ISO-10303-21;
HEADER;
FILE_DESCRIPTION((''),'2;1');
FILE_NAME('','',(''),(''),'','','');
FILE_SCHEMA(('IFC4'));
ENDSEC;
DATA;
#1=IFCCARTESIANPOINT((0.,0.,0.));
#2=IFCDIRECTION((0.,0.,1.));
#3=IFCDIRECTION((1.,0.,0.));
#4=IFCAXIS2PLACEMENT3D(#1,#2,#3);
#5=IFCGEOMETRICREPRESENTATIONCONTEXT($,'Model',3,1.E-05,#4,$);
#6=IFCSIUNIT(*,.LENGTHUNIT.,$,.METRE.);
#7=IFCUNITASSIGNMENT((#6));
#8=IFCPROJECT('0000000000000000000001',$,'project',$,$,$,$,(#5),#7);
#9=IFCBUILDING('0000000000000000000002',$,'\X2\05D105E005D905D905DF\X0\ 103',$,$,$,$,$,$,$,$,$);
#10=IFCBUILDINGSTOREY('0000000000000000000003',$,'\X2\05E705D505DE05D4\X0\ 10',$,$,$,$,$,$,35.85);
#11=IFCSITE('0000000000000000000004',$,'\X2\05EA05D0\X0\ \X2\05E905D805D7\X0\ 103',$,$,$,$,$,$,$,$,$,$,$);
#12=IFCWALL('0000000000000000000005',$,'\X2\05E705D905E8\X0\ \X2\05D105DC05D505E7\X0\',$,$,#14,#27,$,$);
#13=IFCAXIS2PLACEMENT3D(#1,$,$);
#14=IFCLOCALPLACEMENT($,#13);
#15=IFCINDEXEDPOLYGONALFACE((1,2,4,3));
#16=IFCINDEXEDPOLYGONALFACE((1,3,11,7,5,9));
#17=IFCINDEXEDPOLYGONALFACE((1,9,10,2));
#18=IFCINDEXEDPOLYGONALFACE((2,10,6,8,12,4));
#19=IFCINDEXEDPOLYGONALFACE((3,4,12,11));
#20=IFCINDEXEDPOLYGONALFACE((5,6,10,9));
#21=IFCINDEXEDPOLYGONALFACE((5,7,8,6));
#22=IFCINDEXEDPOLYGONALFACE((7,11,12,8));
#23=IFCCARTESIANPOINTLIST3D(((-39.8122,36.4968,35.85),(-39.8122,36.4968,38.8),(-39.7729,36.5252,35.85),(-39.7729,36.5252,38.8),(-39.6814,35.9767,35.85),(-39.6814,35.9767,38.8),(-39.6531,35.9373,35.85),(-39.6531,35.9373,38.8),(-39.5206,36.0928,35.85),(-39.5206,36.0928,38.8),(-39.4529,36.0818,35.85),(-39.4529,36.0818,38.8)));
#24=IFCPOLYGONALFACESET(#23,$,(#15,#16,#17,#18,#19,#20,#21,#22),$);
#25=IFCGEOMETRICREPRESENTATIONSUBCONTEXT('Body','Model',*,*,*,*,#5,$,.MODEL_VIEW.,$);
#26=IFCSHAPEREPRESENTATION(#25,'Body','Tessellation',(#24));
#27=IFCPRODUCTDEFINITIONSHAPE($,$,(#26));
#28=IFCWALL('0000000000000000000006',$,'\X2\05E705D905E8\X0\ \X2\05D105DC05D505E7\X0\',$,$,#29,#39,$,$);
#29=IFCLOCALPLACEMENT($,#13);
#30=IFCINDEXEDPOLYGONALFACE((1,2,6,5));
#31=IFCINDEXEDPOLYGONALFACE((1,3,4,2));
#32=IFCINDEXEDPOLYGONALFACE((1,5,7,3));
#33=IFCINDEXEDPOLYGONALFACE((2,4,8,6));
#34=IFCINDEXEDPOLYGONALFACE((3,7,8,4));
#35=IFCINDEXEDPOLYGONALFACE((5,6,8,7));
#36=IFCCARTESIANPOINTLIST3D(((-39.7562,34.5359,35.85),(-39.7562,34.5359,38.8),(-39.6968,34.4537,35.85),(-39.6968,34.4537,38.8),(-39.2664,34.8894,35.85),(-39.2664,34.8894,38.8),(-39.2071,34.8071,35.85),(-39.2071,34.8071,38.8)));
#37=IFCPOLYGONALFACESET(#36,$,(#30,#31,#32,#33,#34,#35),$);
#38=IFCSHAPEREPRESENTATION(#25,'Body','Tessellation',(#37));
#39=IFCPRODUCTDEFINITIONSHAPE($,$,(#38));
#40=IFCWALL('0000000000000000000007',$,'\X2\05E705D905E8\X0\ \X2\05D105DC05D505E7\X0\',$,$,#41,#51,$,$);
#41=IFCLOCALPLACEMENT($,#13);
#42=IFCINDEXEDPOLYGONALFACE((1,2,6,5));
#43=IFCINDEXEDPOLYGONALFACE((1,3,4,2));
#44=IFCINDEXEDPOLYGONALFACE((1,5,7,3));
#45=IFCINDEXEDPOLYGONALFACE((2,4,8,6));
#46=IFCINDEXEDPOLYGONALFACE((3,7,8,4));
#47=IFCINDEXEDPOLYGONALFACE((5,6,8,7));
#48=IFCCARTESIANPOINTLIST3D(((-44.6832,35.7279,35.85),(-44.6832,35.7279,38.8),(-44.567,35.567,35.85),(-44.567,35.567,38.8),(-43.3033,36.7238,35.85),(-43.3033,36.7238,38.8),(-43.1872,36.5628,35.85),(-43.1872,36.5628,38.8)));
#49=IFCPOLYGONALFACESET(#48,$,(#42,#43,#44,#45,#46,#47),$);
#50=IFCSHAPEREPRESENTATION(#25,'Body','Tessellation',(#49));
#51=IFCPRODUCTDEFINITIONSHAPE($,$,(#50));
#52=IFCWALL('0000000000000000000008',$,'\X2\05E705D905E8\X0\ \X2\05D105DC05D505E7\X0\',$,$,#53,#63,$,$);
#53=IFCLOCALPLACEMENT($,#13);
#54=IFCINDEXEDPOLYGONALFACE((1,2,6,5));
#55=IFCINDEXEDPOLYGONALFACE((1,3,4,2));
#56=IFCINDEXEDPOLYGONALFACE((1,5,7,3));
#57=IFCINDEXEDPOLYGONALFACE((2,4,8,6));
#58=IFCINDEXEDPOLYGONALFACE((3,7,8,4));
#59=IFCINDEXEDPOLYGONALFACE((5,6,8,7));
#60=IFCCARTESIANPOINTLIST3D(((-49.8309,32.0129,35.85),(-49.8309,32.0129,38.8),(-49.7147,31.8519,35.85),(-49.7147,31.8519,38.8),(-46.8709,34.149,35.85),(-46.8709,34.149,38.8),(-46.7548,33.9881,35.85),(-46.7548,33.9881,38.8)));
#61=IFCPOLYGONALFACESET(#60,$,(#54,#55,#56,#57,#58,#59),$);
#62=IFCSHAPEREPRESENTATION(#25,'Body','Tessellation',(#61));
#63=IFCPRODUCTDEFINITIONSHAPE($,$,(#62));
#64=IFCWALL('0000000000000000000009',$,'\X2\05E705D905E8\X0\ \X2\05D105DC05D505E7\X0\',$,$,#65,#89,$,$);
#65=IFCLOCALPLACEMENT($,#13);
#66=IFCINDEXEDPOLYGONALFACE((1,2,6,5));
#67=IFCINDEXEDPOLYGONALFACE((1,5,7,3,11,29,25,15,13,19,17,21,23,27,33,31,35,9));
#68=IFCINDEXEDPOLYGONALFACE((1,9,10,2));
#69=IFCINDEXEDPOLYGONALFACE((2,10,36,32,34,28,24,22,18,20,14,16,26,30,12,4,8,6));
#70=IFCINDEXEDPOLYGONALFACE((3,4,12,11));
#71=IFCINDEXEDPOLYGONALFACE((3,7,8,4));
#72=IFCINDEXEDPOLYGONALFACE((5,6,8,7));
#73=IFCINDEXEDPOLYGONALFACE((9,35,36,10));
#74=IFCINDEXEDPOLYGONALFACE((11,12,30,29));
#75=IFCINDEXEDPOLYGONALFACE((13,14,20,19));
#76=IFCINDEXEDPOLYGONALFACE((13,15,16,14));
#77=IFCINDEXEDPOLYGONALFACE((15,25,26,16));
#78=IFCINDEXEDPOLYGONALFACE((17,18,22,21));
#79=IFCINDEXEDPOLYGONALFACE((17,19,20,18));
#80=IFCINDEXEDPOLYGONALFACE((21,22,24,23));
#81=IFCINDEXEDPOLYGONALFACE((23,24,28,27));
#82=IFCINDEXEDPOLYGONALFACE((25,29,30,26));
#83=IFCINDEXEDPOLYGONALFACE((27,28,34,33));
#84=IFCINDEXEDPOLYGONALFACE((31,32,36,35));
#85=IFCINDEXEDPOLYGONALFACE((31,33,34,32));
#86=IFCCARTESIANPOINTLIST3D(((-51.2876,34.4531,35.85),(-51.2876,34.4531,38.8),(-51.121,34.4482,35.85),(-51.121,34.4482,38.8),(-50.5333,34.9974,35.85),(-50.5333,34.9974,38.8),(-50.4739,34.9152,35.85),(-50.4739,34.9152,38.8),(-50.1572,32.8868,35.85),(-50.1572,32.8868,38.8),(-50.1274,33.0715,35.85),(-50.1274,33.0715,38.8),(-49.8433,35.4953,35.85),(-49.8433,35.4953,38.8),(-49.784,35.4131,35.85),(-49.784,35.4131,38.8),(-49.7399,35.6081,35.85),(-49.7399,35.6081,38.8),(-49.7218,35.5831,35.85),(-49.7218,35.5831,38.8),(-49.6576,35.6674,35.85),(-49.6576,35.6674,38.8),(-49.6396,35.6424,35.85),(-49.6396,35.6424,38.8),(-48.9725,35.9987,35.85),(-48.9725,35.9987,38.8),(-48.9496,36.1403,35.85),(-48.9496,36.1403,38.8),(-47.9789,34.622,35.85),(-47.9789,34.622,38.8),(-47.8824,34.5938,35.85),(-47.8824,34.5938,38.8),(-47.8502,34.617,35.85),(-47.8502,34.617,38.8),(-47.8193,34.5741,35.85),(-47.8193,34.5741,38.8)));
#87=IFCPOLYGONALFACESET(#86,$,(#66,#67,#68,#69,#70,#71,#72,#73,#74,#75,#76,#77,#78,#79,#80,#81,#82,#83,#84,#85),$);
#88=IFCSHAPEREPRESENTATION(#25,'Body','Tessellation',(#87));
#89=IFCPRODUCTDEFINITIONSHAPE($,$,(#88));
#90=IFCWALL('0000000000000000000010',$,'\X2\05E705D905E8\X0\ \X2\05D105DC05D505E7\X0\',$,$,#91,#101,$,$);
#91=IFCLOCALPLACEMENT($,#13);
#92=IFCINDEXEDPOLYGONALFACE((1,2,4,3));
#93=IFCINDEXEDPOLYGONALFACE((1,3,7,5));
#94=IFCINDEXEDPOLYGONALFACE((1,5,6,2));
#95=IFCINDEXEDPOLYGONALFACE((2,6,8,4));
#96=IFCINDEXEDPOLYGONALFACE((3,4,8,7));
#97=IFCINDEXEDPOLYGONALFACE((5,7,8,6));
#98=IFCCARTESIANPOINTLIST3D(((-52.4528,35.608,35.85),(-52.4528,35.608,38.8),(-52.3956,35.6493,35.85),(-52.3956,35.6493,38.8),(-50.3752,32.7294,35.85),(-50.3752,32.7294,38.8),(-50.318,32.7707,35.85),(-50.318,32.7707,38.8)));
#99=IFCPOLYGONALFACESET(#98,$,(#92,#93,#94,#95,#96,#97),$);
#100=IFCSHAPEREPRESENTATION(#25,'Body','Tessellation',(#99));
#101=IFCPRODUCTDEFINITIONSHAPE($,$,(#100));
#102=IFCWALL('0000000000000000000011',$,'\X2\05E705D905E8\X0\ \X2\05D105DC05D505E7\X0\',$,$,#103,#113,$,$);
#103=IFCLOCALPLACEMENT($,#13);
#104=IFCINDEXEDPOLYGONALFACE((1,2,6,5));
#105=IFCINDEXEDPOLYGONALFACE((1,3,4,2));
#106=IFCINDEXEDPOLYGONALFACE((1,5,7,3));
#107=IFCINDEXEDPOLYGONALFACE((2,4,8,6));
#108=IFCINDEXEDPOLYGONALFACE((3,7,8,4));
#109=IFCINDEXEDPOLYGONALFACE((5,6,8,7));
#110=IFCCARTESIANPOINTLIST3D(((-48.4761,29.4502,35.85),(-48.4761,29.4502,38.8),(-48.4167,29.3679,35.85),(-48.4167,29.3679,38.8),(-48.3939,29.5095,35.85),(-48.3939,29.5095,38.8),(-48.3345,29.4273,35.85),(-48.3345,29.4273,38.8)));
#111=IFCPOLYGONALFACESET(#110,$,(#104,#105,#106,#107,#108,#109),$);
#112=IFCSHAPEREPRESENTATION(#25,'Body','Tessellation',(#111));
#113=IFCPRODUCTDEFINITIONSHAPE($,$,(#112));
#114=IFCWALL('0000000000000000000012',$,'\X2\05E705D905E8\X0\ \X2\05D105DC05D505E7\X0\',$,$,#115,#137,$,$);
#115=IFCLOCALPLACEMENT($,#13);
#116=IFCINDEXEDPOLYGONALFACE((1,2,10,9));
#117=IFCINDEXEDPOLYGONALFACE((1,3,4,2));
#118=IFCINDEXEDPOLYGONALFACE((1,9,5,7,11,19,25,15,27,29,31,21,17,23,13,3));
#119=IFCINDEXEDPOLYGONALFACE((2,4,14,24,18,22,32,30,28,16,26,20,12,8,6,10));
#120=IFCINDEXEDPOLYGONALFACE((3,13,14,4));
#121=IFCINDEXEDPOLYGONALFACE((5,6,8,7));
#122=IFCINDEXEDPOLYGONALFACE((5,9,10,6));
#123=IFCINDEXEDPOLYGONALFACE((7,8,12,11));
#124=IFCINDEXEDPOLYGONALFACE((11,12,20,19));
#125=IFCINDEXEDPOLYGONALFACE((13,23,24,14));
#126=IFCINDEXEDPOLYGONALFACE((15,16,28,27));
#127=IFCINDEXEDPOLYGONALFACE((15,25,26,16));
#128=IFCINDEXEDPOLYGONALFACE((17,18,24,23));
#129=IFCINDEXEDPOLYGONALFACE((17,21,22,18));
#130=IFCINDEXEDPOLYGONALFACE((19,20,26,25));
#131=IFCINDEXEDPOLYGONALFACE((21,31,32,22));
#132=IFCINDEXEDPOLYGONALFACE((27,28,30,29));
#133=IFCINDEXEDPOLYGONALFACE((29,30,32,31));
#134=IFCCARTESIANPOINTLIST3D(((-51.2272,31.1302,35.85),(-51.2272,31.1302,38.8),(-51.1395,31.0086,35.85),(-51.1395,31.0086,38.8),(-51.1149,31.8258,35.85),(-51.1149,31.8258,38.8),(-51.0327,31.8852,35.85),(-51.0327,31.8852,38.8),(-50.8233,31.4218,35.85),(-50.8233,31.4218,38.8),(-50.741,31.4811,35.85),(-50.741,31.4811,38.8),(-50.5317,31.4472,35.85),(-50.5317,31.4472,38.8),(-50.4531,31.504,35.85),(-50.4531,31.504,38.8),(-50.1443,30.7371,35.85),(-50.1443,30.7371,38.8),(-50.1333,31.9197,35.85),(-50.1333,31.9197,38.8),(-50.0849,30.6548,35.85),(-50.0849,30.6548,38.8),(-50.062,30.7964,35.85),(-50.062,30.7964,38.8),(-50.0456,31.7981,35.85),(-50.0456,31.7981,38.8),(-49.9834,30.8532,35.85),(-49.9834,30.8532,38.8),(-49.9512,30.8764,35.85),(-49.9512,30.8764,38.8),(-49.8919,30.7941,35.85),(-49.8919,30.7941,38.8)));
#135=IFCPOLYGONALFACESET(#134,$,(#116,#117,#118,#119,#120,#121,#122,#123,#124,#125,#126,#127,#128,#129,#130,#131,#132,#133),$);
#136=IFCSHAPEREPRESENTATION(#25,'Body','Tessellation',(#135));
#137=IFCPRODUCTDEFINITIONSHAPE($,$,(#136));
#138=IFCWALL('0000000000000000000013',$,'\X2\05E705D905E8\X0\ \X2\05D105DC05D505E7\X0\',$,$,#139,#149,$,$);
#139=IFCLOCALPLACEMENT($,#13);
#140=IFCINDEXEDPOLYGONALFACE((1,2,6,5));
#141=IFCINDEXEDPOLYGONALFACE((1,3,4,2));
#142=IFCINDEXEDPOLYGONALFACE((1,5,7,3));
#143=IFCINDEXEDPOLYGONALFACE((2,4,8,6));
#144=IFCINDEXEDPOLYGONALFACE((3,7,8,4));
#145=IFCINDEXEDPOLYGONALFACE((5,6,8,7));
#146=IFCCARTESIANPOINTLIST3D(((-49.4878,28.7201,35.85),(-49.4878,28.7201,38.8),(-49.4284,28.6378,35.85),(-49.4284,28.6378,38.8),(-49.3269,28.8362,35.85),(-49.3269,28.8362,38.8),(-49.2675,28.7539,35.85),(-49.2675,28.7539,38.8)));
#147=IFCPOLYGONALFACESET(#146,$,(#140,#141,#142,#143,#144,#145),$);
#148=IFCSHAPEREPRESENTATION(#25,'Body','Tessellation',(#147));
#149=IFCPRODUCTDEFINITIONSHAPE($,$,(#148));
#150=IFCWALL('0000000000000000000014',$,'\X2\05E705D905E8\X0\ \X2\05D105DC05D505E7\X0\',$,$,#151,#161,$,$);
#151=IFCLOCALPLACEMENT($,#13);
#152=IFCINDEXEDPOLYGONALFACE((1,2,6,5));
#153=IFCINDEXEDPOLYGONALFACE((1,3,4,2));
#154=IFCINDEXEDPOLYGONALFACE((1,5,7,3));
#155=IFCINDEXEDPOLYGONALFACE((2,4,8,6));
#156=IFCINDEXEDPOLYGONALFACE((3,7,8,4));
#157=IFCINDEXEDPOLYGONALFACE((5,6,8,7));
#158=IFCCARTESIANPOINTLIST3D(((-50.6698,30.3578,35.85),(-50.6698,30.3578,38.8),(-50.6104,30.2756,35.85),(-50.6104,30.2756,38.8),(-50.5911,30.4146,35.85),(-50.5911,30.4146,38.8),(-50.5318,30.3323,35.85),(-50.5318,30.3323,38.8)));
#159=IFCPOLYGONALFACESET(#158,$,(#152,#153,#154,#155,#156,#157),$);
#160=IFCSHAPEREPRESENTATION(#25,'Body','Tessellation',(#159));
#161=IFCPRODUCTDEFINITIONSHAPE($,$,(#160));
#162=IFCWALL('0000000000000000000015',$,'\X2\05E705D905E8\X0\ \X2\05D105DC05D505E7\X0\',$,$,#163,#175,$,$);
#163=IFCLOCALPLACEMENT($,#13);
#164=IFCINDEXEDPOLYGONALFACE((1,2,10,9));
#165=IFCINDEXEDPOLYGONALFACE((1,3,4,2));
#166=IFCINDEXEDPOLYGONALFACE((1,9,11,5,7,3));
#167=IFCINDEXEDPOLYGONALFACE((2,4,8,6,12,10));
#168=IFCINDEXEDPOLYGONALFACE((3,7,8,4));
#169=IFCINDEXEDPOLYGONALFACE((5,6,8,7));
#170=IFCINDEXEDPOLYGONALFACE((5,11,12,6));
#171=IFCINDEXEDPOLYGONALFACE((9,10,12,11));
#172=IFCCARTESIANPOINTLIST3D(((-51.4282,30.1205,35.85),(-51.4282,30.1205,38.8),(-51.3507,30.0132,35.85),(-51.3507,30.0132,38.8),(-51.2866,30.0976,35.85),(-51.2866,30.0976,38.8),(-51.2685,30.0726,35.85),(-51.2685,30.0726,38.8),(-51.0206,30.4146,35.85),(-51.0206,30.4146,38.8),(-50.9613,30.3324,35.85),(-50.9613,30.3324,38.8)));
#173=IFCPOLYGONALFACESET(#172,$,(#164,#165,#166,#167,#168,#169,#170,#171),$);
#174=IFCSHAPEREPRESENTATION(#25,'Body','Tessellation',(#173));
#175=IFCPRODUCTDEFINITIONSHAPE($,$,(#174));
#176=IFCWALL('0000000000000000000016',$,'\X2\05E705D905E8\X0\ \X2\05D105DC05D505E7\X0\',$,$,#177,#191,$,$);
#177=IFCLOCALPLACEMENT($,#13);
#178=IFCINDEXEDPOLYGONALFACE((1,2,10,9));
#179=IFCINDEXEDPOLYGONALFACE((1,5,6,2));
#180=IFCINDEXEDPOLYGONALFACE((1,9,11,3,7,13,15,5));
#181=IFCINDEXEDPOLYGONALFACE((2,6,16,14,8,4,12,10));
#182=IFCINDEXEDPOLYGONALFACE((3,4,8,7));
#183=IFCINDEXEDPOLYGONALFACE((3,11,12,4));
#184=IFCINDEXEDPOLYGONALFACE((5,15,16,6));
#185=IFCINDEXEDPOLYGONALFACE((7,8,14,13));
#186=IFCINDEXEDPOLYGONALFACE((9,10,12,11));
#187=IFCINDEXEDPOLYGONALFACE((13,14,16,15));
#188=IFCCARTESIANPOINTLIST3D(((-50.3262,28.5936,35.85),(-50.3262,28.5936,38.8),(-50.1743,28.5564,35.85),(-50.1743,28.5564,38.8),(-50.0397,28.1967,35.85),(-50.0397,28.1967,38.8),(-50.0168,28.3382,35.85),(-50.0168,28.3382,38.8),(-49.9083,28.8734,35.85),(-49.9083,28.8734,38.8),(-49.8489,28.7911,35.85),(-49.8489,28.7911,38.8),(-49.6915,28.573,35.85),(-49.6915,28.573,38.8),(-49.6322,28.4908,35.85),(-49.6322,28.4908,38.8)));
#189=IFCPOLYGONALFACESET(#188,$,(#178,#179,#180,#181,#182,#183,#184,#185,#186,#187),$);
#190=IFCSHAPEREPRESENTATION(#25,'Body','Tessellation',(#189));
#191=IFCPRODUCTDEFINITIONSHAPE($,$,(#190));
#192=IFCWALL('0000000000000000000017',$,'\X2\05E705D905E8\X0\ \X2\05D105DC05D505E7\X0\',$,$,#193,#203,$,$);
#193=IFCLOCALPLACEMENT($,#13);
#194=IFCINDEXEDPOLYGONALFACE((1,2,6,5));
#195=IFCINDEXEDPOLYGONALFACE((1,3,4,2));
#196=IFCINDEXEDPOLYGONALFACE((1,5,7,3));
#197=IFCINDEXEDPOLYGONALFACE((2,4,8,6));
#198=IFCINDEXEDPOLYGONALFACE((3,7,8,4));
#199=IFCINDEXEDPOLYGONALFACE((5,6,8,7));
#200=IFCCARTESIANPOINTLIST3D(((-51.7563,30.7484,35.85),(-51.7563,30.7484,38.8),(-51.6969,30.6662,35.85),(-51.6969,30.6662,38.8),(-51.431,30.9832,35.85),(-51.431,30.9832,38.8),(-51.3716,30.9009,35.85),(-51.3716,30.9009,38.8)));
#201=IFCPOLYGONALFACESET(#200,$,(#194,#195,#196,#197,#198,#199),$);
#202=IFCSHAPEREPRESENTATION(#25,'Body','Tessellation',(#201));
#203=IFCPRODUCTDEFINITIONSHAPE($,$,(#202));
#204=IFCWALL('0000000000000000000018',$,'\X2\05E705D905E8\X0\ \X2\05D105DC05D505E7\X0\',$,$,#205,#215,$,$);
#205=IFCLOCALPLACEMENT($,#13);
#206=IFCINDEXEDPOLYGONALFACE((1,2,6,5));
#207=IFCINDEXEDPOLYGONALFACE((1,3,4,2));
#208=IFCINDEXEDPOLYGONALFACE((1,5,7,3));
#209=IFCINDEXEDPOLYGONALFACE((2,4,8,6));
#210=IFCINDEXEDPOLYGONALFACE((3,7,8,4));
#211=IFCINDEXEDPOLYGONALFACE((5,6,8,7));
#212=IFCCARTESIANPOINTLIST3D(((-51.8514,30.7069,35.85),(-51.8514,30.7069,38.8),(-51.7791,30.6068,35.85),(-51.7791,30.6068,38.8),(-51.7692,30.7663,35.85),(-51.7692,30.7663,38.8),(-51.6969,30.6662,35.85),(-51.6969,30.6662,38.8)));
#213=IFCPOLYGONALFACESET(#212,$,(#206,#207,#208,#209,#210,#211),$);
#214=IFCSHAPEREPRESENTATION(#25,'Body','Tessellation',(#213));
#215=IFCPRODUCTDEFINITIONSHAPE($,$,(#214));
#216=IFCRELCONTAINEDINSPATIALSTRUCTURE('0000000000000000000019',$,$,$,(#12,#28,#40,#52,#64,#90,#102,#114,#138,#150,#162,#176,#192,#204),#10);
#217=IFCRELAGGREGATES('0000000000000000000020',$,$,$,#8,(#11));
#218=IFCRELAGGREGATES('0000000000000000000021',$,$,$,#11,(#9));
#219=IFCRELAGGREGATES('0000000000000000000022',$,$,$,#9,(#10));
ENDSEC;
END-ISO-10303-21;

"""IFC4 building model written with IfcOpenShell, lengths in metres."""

from ifc_helpers import new_model, si_unit, frame, origin_with_axes, context, subcontext, project, spatial, polyline, outline, extrude, element, save


model = new_model("IFC4")

# Units and contexts
model_context = context("Model", 3, precision=1e-05, world=origin_with_axes())
body_context = subcontext(model_context, "Body", "Model", "MODEL_VIEW")
ifc_project = project(units=[si_unit("LENGTHUNIT", "METRE")], contexts=[model_context])

# Site, building, storey
site = spatial("IfcSite", under=ifc_project, Name="תא שטח 103")
building = spatial("IfcBuilding", under=site, Name="בניין 103")
storey = spatial("IfcBuildingStorey", under=building, Name="קומה 10", Elevation=35.85)

# Walls
element("IfcWall", 1, inside=storey, Name="קיר בלוק", context=body_context, shape_type="SweptSolid", body=[
    extrude(outline(polyline([(-39.6814, 35.9767), (-39.5206, 36.0928), (-39.8122, 36.4968), (-39.7729, 36.5252), (-39.4529, 36.0818), (-39.6531, 35.9373), (-39.6814, 35.9767)])), frame((0.0, 0.0, 35.85)), (0.0, 0.0, 1.0), 2.95),
])
element("IfcWall", 2, inside=storey, Name="קיר בלוק", context=body_context, shape_type="SweptSolid", body=[
    extrude(outline(polyline([(-39.2071, 34.8071), (-39.6968, 34.4537), (-39.7562, 34.5359), (-39.2664, 34.8894), (-39.2071, 34.8071)])), frame((0.0, 0.0, 35.85)), (0.0, 0.0, 1.0), 2.95),
])
element("IfcWall", 3, inside=storey, Name="קיר בלוק", context=body_context, shape_type="SweptSolid", body=[
    extrude(outline(polyline([(-44.567, 35.567), (-44.6832, 35.7279), (-43.3033, 36.7238), (-43.1872, 36.5628), (-44.567, 35.567)])), frame((0.0, 0.0, 35.85)), (0.0, 0.0, 1.0), 2.95),
])
element("IfcWall", 4, inside=storey, Name="קיר בלוק", context=body_context, shape_type="SweptSolid", body=[
    extrude(outline(polyline([(-49.7147, 31.8519), (-49.8309, 32.0129), (-46.8709, 34.149), (-46.7548, 33.9881), (-49.7147, 31.8519)])), frame((0.0, 0.0, 35.85)), (0.0, 0.0, 1.0), 2.95),
])
element("IfcWall", 5, inside=storey, Name="קיר בלוק", context=body_context, shape_type="SweptSolid", body=[
    extrude(outline(polyline([(-50.1572, 32.8868), (-51.2876, 34.4531), (-50.5333, 34.9974), (-50.4739, 34.9152), (-51.121, 34.4482), (-50.1274, 33.0715), (-47.9789, 34.622), (-48.9725, 35.9987), (-49.784, 35.4131), (-49.8433, 35.4953), (-49.7218, 35.5831), (-49.7399, 35.6081), (-49.6576, 35.6674), (-49.6396, 35.6424), (-48.9496, 36.1403), (-47.8502, 34.617), (-47.8824, 34.5938), (-47.8193, 34.5741), (-50.1572, 32.8868)])), frame((0.0, 0.0, 35.85)), (0.0, 0.0, 1.0), 2.95),
])
element("IfcWall", 6, inside=storey, Name="קיר בלוק", context=body_context, shape_type="SweptSolid", body=[
    extrude(outline(polyline([(-52.4528, 35.608), (-52.3956, 35.6493), (-50.318, 32.7707), (-50.3752, 32.7294), (-52.4528, 35.608)])), frame((0.0, 0.0, 35.85)), (0.0, 0.0, 1.0), 2.95),
])
element("IfcWall", 7, inside=storey, Name="קיר בלוק", context=body_context, shape_type="SweptSolid", body=[
    extrude(outline(polyline([(-48.3345, 29.4273), (-48.4167, 29.3679), (-48.4761, 29.4502), (-48.3939, 29.5095), (-48.3345, 29.4273)])), frame((0.0, 0.0, 35.85)), (0.0, 0.0, 1.0), 2.95),
])
element("IfcWall", 8, inside=storey, Name="קיר בלוק", context=body_context, shape_type="SweptSolid", body=[
    extrude(outline(polyline([(-50.062, 30.7964), (-50.5317, 31.4472), (-51.1395, 31.0086), (-51.2272, 31.1302), (-50.8233, 31.4218), (-51.1149, 31.8258), (-51.0327, 31.8852), (-50.741, 31.4811), (-50.1333, 31.9197), (-50.0456, 31.7981), (-50.4531, 31.504), (-49.9834, 30.8532), (-49.9512, 30.8764), (-49.8919, 30.7941), (-50.0849, 30.6548), (-50.1443, 30.7371), (-50.062, 30.7964)])), frame((0.0, 0.0, 35.85)), (0.0, 0.0, 1.0), 2.95),
])
element("IfcWall", 9, inside=storey, Name="קיר בלוק", context=body_context, shape_type="SweptSolid", body=[
    extrude(outline(polyline([(-49.3269, 28.8362), (-49.2675, 28.7539), (-49.4284, 28.6378), (-49.4878, 28.7201), (-49.3269, 28.8362)])), frame((0.0, 0.0, 35.85)), (0.0, 0.0, 1.0), 2.95),
])
element("IfcWall", 10, inside=storey, Name="קיר בלוק", context=body_context, shape_type="SweptSolid", body=[
    extrude(outline(polyline([(-50.5911, 30.4146), (-50.5318, 30.3323), (-50.6104, 30.2756), (-50.6698, 30.3578), (-50.5911, 30.4146)])), frame((0.0, 0.0, 35.85)), (0.0, 0.0, 1.0), 2.95),
])
element("IfcWall", 11, inside=storey, Name="קיר בלוק", context=body_context, shape_type="SweptSolid", body=[
    extrude(outline(polyline([(-51.3507, 30.0132), (-51.4282, 30.1205), (-51.0206, 30.4146), (-50.9613, 30.3324), (-51.2866, 30.0976), (-51.2685, 30.0726), (-51.3507, 30.0132)])), frame((0.0, 0.0, 35.85)), (0.0, 0.0, 1.0), 2.95),
])
element("IfcWall", 12, inside=storey, Name="קיר בלוק", context=body_context, shape_type="SweptSolid", body=[
    extrude(outline(polyline([(-50.0168, 28.3382), (-49.6915, 28.573), (-49.6322, 28.4908), (-50.0397, 28.1967), (-50.3262, 28.5936), (-49.9083, 28.8734), (-49.8489, 28.7911), (-50.1743, 28.5564), (-50.0168, 28.3382)])), frame((0.0, 0.0, 35.85)), (0.0, 0.0, 1.0), 2.95),
])
element("IfcWall", 13, inside=storey, Name="קיר בלוק", context=body_context, shape_type="SweptSolid", body=[
    extrude(outline(polyline([(-51.3716, 30.9009), (-51.6969, 30.6662), (-51.7563, 30.7484), (-51.431, 30.9832), (-51.3716, 30.9009)])), frame((0.0, 0.0, 35.85)), (0.0, 0.0, 1.0), 2.95),
])
element("IfcWall", 14, inside=storey, Name="קיר בלוק", context=body_context, shape_type="SweptSolid", body=[
    extrude(outline(polyline([(-51.7692, 30.7663), (-51.6969, 30.6662), (-51.7791, 30.6068), (-51.8514, 30.7069), (-51.7692, 30.7663)])), frame((0.0, 0.0, 35.85)), (0.0, 0.0, 1.0), 2.95),
])

save(model, "model.ifc")
